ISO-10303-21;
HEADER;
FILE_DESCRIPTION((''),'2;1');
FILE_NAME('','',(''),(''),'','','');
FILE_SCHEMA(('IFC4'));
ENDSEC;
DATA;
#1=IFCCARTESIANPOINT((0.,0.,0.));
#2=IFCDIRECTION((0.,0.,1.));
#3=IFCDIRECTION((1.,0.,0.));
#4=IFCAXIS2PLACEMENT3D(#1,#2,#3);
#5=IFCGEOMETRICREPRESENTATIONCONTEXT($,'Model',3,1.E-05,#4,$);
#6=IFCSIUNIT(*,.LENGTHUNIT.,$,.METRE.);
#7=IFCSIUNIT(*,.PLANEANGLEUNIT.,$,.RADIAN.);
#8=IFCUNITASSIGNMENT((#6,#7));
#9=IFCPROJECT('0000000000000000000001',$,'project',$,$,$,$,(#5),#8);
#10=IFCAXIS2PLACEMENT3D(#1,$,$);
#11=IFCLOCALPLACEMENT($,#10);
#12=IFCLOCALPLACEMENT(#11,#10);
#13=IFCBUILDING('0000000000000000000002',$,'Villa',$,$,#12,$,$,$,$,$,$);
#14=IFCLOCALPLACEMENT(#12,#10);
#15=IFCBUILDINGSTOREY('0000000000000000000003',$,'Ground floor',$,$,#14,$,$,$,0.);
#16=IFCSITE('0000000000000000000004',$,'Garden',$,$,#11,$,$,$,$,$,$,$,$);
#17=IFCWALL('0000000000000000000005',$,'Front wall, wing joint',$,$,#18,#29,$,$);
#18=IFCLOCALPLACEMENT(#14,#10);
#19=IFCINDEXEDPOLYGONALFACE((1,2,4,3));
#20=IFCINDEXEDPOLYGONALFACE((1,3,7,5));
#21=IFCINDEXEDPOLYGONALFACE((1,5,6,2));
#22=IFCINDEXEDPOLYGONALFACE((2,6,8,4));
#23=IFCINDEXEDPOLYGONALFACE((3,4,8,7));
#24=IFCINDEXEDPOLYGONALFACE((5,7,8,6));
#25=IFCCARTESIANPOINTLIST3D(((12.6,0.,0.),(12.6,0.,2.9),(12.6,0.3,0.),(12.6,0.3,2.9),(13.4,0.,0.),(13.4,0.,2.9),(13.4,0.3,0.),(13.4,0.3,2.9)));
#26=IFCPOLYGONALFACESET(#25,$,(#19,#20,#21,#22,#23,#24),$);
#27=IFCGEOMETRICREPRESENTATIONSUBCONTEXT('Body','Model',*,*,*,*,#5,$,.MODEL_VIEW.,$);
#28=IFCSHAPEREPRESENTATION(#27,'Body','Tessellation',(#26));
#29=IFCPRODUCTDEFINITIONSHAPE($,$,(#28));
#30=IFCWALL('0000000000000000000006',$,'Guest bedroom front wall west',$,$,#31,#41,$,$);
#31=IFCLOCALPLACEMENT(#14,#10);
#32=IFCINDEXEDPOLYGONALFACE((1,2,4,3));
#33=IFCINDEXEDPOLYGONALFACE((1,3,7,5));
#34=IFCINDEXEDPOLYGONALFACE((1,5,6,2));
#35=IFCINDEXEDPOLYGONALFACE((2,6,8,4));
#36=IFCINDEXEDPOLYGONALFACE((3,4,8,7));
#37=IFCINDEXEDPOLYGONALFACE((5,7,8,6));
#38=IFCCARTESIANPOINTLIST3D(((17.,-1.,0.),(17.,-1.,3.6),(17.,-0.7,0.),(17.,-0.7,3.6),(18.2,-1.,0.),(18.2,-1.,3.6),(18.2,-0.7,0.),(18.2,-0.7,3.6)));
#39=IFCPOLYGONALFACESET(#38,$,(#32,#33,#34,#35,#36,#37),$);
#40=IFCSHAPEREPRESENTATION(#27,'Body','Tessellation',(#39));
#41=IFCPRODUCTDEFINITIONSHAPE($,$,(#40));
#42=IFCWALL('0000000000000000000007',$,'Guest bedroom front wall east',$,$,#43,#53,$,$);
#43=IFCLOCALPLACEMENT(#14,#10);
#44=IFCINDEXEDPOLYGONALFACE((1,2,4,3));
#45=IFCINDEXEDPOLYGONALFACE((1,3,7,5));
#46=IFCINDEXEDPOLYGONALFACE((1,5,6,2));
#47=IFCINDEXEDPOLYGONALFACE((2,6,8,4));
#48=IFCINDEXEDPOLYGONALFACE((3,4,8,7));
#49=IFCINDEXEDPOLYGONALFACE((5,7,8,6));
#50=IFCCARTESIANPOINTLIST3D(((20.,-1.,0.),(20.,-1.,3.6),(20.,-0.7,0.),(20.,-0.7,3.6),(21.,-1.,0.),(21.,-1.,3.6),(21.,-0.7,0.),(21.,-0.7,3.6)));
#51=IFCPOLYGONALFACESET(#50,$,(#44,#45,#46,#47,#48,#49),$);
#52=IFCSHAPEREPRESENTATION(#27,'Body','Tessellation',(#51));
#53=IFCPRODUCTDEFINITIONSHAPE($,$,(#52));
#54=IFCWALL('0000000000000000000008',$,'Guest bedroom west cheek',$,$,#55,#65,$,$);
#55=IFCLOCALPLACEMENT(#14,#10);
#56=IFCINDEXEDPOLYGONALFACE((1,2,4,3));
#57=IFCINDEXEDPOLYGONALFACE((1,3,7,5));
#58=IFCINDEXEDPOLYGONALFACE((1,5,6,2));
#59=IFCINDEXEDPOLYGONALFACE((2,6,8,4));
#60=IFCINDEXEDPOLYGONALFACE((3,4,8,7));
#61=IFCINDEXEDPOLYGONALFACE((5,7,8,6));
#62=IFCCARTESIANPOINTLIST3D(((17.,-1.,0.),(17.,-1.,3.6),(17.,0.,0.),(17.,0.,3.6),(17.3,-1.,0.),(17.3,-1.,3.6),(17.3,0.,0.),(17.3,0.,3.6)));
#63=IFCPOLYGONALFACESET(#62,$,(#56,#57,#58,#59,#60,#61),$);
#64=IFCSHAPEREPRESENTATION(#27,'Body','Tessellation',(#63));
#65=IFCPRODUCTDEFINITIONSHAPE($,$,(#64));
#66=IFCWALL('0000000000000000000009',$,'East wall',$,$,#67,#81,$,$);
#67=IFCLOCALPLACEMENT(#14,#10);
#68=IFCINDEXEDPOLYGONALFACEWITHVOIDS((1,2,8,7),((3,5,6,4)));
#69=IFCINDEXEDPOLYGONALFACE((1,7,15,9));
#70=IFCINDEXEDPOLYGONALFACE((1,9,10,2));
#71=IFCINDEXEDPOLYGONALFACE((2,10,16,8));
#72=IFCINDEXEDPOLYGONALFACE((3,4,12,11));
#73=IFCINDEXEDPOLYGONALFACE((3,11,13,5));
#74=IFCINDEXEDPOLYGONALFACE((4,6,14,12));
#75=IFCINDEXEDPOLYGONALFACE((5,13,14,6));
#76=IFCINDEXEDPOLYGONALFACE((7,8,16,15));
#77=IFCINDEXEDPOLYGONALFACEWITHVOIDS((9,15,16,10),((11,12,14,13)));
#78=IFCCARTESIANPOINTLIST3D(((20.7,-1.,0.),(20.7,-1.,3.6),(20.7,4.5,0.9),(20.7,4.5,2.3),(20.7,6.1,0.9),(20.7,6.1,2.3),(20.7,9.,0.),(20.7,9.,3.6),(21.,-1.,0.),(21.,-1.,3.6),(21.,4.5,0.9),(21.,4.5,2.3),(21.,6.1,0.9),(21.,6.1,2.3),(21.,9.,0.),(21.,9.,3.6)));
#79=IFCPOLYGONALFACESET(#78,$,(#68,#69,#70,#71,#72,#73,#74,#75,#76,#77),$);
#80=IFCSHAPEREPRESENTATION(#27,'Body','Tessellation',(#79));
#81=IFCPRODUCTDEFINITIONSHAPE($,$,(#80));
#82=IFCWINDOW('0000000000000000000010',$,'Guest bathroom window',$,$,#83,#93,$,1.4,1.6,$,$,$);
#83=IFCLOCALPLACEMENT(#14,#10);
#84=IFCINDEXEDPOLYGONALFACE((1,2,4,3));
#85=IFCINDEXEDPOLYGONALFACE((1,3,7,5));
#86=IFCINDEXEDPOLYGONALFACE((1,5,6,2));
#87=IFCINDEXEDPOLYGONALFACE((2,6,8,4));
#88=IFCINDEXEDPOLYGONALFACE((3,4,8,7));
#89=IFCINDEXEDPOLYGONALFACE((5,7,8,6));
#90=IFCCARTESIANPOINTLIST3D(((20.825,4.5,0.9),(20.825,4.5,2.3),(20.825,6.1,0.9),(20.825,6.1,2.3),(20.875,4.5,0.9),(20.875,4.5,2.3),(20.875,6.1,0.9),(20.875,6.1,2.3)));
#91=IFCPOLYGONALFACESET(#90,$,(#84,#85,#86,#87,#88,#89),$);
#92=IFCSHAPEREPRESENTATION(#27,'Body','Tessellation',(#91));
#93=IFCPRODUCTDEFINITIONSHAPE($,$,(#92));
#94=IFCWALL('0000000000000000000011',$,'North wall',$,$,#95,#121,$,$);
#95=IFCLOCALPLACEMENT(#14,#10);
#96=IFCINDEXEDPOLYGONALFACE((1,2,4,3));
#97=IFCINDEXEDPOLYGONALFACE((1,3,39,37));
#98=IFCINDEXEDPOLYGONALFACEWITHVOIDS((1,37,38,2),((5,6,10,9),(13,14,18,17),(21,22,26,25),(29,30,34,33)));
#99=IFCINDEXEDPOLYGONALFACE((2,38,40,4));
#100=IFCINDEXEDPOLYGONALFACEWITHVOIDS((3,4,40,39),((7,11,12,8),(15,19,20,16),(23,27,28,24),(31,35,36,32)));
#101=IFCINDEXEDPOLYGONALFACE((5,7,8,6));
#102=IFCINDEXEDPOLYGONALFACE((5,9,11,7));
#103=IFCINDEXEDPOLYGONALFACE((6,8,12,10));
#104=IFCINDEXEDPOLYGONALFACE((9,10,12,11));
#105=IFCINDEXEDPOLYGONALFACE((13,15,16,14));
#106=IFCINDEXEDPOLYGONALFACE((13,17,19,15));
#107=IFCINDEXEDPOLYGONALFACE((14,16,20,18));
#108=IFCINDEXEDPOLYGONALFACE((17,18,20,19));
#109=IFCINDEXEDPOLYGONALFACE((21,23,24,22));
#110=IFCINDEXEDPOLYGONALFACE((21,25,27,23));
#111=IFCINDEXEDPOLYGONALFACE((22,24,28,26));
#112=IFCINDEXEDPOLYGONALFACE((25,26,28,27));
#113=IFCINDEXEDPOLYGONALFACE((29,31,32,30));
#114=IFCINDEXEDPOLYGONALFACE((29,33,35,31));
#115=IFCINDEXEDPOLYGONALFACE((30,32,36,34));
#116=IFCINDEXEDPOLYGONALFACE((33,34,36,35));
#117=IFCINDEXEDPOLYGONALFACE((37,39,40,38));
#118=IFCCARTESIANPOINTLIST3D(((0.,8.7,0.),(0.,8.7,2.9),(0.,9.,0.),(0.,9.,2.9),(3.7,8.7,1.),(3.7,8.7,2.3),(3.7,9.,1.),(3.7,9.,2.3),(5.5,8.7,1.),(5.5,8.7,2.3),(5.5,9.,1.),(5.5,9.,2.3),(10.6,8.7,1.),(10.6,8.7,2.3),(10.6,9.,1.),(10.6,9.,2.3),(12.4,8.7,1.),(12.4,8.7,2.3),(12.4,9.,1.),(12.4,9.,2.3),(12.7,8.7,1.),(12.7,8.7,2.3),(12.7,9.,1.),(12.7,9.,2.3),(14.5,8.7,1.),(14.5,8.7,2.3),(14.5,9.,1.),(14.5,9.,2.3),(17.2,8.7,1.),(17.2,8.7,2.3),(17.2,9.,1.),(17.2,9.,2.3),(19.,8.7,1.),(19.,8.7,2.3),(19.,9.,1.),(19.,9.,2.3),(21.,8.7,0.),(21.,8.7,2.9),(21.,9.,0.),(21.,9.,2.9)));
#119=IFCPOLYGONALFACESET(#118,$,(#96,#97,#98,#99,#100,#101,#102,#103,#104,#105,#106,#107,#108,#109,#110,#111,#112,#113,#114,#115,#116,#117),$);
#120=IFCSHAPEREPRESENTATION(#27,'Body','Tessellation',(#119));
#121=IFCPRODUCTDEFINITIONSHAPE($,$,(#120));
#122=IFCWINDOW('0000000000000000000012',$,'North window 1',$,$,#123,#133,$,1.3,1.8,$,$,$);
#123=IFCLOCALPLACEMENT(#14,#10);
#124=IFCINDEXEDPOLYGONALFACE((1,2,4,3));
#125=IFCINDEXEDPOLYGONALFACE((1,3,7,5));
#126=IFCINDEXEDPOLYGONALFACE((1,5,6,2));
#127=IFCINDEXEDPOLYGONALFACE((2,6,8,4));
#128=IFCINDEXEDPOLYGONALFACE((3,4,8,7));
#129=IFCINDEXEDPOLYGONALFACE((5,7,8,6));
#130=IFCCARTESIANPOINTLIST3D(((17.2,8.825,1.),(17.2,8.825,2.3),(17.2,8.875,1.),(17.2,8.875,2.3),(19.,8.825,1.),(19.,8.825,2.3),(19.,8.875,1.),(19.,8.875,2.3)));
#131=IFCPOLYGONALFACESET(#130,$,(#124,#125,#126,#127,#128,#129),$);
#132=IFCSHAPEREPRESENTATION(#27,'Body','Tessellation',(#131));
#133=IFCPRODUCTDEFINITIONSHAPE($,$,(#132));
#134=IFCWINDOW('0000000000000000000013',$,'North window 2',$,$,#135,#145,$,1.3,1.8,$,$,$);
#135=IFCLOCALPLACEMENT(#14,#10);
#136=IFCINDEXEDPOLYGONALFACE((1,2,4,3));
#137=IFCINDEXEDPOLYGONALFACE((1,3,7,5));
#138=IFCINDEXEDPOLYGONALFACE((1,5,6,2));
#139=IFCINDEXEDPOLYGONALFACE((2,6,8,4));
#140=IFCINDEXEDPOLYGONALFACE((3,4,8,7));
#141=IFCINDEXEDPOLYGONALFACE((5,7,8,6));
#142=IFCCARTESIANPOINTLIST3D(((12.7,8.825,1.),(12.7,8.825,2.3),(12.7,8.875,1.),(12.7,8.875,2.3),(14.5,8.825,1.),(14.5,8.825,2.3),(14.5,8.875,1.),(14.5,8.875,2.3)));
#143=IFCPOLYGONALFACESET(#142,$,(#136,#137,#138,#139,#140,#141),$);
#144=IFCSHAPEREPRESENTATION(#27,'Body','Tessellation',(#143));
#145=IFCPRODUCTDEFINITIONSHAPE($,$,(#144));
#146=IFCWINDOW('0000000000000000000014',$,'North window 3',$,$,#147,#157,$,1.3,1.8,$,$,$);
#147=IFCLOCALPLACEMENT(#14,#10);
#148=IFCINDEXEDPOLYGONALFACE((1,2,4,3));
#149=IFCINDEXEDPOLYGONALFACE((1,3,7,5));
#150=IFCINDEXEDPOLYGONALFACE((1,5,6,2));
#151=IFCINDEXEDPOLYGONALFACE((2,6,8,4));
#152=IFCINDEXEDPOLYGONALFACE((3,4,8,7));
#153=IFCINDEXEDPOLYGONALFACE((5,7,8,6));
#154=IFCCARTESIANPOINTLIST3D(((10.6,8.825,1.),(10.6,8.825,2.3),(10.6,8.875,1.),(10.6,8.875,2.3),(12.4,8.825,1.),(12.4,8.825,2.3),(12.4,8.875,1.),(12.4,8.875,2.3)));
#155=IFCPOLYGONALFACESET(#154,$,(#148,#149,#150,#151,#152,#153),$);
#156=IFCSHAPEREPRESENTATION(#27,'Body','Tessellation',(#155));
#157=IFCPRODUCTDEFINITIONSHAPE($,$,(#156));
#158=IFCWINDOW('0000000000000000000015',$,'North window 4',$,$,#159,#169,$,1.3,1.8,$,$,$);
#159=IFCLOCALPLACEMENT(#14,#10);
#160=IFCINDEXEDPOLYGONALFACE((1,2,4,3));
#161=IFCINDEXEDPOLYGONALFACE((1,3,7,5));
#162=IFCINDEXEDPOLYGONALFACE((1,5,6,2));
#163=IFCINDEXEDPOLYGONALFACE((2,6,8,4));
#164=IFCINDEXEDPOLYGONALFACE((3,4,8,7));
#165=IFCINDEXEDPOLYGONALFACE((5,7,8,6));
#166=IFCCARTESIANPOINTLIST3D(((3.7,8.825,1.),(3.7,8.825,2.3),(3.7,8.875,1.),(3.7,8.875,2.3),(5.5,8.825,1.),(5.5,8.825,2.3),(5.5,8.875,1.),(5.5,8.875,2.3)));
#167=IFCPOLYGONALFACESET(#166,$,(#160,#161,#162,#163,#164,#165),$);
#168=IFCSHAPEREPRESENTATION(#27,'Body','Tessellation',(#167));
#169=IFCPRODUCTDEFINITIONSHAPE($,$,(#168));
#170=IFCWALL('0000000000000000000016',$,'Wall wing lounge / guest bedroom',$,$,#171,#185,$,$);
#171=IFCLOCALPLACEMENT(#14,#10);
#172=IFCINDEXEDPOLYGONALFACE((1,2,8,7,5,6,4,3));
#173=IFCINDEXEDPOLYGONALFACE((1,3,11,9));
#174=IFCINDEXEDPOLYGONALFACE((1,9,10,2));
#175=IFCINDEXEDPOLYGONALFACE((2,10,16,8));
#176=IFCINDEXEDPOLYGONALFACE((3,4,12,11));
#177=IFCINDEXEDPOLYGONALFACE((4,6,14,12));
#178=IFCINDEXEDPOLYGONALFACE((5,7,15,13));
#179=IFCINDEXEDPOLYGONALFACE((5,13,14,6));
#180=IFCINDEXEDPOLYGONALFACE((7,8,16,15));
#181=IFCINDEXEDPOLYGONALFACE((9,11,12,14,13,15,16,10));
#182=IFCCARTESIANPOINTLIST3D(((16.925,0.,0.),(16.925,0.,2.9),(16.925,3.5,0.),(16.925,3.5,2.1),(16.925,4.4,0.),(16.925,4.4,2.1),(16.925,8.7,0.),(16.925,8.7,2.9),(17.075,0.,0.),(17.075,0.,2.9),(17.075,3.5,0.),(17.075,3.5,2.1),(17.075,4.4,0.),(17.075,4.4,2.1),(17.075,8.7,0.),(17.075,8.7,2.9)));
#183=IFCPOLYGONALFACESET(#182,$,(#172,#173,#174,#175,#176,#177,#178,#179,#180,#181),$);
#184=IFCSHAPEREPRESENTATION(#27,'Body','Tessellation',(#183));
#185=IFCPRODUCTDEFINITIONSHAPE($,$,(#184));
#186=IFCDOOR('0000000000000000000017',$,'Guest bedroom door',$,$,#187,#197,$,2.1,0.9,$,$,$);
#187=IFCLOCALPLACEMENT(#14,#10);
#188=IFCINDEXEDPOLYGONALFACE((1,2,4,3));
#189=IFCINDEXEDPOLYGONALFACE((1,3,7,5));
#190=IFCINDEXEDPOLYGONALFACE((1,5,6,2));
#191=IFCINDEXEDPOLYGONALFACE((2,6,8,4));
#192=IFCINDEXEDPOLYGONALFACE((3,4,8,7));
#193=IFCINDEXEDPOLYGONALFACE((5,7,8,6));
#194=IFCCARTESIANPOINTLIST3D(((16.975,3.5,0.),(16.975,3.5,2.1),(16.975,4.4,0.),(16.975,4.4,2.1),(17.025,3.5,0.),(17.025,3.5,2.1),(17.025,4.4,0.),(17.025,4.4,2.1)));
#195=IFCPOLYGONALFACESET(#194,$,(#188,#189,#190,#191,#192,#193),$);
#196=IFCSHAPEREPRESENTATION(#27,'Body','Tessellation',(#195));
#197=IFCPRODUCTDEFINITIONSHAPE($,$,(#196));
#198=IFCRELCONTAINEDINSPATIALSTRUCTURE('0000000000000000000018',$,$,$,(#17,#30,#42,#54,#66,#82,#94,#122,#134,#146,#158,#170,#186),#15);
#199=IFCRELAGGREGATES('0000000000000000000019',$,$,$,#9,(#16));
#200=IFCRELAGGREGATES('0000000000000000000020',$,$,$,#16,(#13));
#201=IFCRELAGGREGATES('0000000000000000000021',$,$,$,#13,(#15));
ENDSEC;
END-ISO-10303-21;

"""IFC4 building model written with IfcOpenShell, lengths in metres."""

from ifc_helpers import new_model, si_unit, frame, frame_2d, origin, origin_with_axes, place, context, subcontext, project, spatial, rectangle, extrude, element, fill, save


model = new_model("IFC4")

# Units and contexts
model_context = context("Model", 3, precision=1e-05, world=origin_with_axes())
body_context = subcontext(model_context, "Body", "Model", "MODEL_VIEW")
ifc_project = project(units=[si_unit("LENGTHUNIT", "METRE"), si_unit("PLANEANGLEUNIT", "RADIAN")], contexts=[model_context])

# Site, building, storey
site_placement = place(None, origin())
site = spatial("IfcSite", under=ifc_project, at=site_placement, Name="Garden")
building_placement = place(site_placement, origin())
building = spatial("IfcBuilding", under=site, at=building_placement, Name="Villa")
storey_placement = place(building_placement, origin())
storey = spatial("IfcBuildingStorey", under=building, at=storey_placement, Name="Ground floor", Elevation=0.0)

# Walls
wall_1_placement = place(storey_placement, frame((12.6, 0.15, 0.0)))
element("IfcWall", 1, at=wall_1_placement, inside=storey, Name="Front wall, wing joint", context=body_context, shape_type="SweptSolid", body=[
    extrude(rectangle(XDim=0.8, YDim=0.3, at=frame_2d((0.4, 0.0))), origin(), (0.0, 0.0, 1.0), 2.9),
])
wall_2_placement = place(storey_placement, frame((17.0, -0.85, 0.0)))
element("IfcWall", 2, at=wall_2_placement, inside=storey, Name="Guest bedroom front wall west", context=body_context, shape_type="SweptSolid", body=[
    extrude(rectangle(XDim=1.2, YDim=0.3, at=frame_2d((0.6, 0.0))), origin(), (0.0, 0.0, 1.0), 3.6),
])
wall_3_placement = place(storey_placement, frame((20.0, -0.85, 0.0)))
element("IfcWall", 3, at=wall_3_placement, inside=storey, Name="Guest bedroom front wall east", context=body_context, shape_type="SweptSolid", body=[
    extrude(rectangle(XDim=1.0, YDim=0.3, at=frame_2d((0.5, 0.0))), origin(), (0.0, 0.0, 1.0), 3.6),
])
wall_4_placement = place(storey_placement, frame((17.15, -1.0, 0.0), x_axis=(0.0, 1.0, 0.0)))
element("IfcWall", 4, at=wall_4_placement, inside=storey, Name="Guest bedroom west cheek", context=body_context, shape_type="SweptSolid", body=[
    extrude(rectangle(XDim=1.0, YDim=0.3, at=frame_2d((0.5, 0.0))), origin(), (0.0, 0.0, 1.0), 3.6),
])

# Wall, opening, window
wall_5_placement = place(storey_placement, frame((20.85, -1.0, 0.0), x_axis=(0.0, 1.0, 0.0)))
wall_5 = element("IfcWall", 5, at=wall_5_placement, inside=storey, Name="East wall", context=body_context, shape_type="SweptSolid", body=[
    extrude(rectangle(XDim=10.0, YDim=0.3, at=frame_2d((5.0, 0.0))), origin(), (0.0, 0.0, 1.0), 3.6),
])
opening_1_placement = place(wall_5_placement, frame((5.5, 0.0, 0.9)))
opening_1 = element("IfcOpeningElement", 6, at=opening_1_placement, cuts=wall_5, context=body_context, shape_type="SweptSolid", body=[
    extrude(rectangle(XDim=1.6, YDim=0.4, at=frame_2d((0.8, 0.0))), origin(), (0.0, 0.0, 1.0), 1.4),
])
window_1_placement = place(opening_1_placement, origin())
window_1 = element("IfcWindow", 7, at=window_1_placement, inside=storey, Name="Guest bathroom window", OverallHeight=1.4, OverallWidth=1.6, context=body_context, shape_type="SweptSolid", body=[
    extrude(rectangle(XDim=1.6, YDim=0.05, at=frame_2d((0.8, 0.0))), origin(), (0.0, 0.0, 1.0), 1.4),
])
fill(opening_1, window_1)

# Wall, openings, windows
wall_6_placement = place(storey_placement, frame((21.0, 8.85, 0.0), x_axis=(-1.0, 0.0, 0.0)))
wall_6 = element("IfcWall", 8, at=wall_6_placement, inside=storey, Name="North wall", context=body_context, shape_type="SweptSolid", body=[
    extrude(rectangle(XDim=21.0, YDim=0.3, at=frame_2d((10.5, 0.0))), origin(), (0.0, 0.0, 1.0), 2.9),
])
opening_2_placement = place(wall_6_placement, frame((2.0, 0.0, 1.0)))
opening_2 = element("IfcOpeningElement", 9, at=opening_2_placement, cuts=wall_6, context=body_context, shape_type="SweptSolid", body=[
    extrude(rectangle(XDim=1.8, YDim=0.4, at=frame_2d((0.9, 0.0))), origin(), (0.0, 0.0, 1.0), 1.3),
])
opening_3_placement = place(wall_6_placement, frame((6.5, 0.0, 1.0)))
opening_3 = element("IfcOpeningElement", 10, at=opening_3_placement, cuts=wall_6, context=body_context, shape_type="SweptSolid", body=[
    extrude(rectangle(XDim=1.8, YDim=0.4, at=frame_2d((0.9, 0.0))), origin(), (0.0, 0.0, 1.0), 1.3),
])
opening_4_placement = place(wall_6_placement, frame((8.6, 0.0, 1.0)))
opening_4 = element("IfcOpeningElement", 11, at=opening_4_placement, cuts=wall_6, context=body_context, shape_type="SweptSolid", body=[
    extrude(rectangle(XDim=1.8, YDim=0.4, at=frame_2d((0.9, 0.0))), origin(), (0.0, 0.0, 1.0), 1.3),
])
opening_5_placement = place(wall_6_placement, frame((15.5, 0.0, 1.0)))
opening_5 = element("IfcOpeningElement", 12, at=opening_5_placement, cuts=wall_6, context=body_context, shape_type="SweptSolid", body=[
    extrude(rectangle(XDim=1.8, YDim=0.4, at=frame_2d((0.9, 0.0))), origin(), (0.0, 0.0, 1.0), 1.3),
])
window_2_placement = place(opening_2_placement, origin())
window_2 = element("IfcWindow", 13, at=window_2_placement, inside=storey, Name="North window 1", OverallHeight=1.3, OverallWidth=1.8, context=body_context, shape_type="SweptSolid", body=[
    extrude(rectangle(XDim=1.8, YDim=0.05, at=frame_2d((0.9, 0.0))), origin(), (0.0, 0.0, 1.0), 1.3),
])
fill(opening_2, window_2)
window_3_placement = place(opening_3_placement, origin())
window_3 = element("IfcWindow", 14, at=window_3_placement, inside=storey, Name="North window 2", OverallHeight=1.3, OverallWidth=1.8, context=body_context, shape_type="SweptSolid", body=[
    extrude(rectangle(XDim=1.8, YDim=0.05, at=frame_2d((0.9, 0.0))), origin(), (0.0, 0.0, 1.0), 1.3),
])
fill(opening_3, window_3)
window_4_placement = place(opening_4_placement, origin())
window_4 = element("IfcWindow", 15, at=window_4_placement, inside=storey, Name="North window 3", OverallHeight=1.3, OverallWidth=1.8, context=body_context, shape_type="SweptSolid", body=[
    extrude(rectangle(XDim=1.8, YDim=0.05, at=frame_2d((0.9, 0.0))), origin(), (0.0, 0.0, 1.0), 1.3),
])
fill(opening_4, window_4)
window_5_placement = place(opening_5_placement, origin())
window_5 = element("IfcWindow", 16, at=window_5_placement, inside=storey, Name="North window 4", OverallHeight=1.3, OverallWidth=1.8, context=body_context, shape_type="SweptSolid", body=[
    extrude(rectangle(XDim=1.8, YDim=0.05, at=frame_2d((0.9, 0.0))), origin(), (0.0, 0.0, 1.0), 1.3),
])
fill(opening_5, window_5)

# Wall, opening, door
wall_7_placement = place(storey_placement, frame((17.0, 0.0, 0.0), x_axis=(0.0, 1.0, 0.0)))
wall_7 = element("IfcWall", 17, at=wall_7_placement, inside=storey, Name="Wall wing lounge / guest bedroom", context=body_context, shape_type="SweptSolid", body=[
    extrude(rectangle(XDim=8.7, YDim=0.15, at=frame_2d((4.35, 0.0))), origin(), (0.0, 0.0, 1.0), 2.9),
])
opening_6_placement = place(wall_7_placement, frame((3.5, 0.0, 0.0)))
opening_6 = element("IfcOpeningElement", 18, at=opening_6_placement, cuts=wall_7, context=body_context, shape_type="SweptSolid", body=[
    extrude(rectangle(XDim=0.9, YDim=0.25, at=frame_2d((0.45, 0.0))), origin(), (0.0, 0.0, 1.0), 2.1),
])
door_placement = place(opening_6_placement, origin())
door = element("IfcDoor", 19, at=door_placement, inside=storey, Name="Guest bedroom door", OverallHeight=2.1, OverallWidth=0.9, context=body_context, shape_type="SweptSolid", body=[
    extrude(rectangle(XDim=0.9, YDim=0.05, at=frame_2d((0.45, 0.0))), origin(), (0.0, 0.0, 1.0), 2.1),
])
fill(opening_6, door)

save(model, "model.ifc")
